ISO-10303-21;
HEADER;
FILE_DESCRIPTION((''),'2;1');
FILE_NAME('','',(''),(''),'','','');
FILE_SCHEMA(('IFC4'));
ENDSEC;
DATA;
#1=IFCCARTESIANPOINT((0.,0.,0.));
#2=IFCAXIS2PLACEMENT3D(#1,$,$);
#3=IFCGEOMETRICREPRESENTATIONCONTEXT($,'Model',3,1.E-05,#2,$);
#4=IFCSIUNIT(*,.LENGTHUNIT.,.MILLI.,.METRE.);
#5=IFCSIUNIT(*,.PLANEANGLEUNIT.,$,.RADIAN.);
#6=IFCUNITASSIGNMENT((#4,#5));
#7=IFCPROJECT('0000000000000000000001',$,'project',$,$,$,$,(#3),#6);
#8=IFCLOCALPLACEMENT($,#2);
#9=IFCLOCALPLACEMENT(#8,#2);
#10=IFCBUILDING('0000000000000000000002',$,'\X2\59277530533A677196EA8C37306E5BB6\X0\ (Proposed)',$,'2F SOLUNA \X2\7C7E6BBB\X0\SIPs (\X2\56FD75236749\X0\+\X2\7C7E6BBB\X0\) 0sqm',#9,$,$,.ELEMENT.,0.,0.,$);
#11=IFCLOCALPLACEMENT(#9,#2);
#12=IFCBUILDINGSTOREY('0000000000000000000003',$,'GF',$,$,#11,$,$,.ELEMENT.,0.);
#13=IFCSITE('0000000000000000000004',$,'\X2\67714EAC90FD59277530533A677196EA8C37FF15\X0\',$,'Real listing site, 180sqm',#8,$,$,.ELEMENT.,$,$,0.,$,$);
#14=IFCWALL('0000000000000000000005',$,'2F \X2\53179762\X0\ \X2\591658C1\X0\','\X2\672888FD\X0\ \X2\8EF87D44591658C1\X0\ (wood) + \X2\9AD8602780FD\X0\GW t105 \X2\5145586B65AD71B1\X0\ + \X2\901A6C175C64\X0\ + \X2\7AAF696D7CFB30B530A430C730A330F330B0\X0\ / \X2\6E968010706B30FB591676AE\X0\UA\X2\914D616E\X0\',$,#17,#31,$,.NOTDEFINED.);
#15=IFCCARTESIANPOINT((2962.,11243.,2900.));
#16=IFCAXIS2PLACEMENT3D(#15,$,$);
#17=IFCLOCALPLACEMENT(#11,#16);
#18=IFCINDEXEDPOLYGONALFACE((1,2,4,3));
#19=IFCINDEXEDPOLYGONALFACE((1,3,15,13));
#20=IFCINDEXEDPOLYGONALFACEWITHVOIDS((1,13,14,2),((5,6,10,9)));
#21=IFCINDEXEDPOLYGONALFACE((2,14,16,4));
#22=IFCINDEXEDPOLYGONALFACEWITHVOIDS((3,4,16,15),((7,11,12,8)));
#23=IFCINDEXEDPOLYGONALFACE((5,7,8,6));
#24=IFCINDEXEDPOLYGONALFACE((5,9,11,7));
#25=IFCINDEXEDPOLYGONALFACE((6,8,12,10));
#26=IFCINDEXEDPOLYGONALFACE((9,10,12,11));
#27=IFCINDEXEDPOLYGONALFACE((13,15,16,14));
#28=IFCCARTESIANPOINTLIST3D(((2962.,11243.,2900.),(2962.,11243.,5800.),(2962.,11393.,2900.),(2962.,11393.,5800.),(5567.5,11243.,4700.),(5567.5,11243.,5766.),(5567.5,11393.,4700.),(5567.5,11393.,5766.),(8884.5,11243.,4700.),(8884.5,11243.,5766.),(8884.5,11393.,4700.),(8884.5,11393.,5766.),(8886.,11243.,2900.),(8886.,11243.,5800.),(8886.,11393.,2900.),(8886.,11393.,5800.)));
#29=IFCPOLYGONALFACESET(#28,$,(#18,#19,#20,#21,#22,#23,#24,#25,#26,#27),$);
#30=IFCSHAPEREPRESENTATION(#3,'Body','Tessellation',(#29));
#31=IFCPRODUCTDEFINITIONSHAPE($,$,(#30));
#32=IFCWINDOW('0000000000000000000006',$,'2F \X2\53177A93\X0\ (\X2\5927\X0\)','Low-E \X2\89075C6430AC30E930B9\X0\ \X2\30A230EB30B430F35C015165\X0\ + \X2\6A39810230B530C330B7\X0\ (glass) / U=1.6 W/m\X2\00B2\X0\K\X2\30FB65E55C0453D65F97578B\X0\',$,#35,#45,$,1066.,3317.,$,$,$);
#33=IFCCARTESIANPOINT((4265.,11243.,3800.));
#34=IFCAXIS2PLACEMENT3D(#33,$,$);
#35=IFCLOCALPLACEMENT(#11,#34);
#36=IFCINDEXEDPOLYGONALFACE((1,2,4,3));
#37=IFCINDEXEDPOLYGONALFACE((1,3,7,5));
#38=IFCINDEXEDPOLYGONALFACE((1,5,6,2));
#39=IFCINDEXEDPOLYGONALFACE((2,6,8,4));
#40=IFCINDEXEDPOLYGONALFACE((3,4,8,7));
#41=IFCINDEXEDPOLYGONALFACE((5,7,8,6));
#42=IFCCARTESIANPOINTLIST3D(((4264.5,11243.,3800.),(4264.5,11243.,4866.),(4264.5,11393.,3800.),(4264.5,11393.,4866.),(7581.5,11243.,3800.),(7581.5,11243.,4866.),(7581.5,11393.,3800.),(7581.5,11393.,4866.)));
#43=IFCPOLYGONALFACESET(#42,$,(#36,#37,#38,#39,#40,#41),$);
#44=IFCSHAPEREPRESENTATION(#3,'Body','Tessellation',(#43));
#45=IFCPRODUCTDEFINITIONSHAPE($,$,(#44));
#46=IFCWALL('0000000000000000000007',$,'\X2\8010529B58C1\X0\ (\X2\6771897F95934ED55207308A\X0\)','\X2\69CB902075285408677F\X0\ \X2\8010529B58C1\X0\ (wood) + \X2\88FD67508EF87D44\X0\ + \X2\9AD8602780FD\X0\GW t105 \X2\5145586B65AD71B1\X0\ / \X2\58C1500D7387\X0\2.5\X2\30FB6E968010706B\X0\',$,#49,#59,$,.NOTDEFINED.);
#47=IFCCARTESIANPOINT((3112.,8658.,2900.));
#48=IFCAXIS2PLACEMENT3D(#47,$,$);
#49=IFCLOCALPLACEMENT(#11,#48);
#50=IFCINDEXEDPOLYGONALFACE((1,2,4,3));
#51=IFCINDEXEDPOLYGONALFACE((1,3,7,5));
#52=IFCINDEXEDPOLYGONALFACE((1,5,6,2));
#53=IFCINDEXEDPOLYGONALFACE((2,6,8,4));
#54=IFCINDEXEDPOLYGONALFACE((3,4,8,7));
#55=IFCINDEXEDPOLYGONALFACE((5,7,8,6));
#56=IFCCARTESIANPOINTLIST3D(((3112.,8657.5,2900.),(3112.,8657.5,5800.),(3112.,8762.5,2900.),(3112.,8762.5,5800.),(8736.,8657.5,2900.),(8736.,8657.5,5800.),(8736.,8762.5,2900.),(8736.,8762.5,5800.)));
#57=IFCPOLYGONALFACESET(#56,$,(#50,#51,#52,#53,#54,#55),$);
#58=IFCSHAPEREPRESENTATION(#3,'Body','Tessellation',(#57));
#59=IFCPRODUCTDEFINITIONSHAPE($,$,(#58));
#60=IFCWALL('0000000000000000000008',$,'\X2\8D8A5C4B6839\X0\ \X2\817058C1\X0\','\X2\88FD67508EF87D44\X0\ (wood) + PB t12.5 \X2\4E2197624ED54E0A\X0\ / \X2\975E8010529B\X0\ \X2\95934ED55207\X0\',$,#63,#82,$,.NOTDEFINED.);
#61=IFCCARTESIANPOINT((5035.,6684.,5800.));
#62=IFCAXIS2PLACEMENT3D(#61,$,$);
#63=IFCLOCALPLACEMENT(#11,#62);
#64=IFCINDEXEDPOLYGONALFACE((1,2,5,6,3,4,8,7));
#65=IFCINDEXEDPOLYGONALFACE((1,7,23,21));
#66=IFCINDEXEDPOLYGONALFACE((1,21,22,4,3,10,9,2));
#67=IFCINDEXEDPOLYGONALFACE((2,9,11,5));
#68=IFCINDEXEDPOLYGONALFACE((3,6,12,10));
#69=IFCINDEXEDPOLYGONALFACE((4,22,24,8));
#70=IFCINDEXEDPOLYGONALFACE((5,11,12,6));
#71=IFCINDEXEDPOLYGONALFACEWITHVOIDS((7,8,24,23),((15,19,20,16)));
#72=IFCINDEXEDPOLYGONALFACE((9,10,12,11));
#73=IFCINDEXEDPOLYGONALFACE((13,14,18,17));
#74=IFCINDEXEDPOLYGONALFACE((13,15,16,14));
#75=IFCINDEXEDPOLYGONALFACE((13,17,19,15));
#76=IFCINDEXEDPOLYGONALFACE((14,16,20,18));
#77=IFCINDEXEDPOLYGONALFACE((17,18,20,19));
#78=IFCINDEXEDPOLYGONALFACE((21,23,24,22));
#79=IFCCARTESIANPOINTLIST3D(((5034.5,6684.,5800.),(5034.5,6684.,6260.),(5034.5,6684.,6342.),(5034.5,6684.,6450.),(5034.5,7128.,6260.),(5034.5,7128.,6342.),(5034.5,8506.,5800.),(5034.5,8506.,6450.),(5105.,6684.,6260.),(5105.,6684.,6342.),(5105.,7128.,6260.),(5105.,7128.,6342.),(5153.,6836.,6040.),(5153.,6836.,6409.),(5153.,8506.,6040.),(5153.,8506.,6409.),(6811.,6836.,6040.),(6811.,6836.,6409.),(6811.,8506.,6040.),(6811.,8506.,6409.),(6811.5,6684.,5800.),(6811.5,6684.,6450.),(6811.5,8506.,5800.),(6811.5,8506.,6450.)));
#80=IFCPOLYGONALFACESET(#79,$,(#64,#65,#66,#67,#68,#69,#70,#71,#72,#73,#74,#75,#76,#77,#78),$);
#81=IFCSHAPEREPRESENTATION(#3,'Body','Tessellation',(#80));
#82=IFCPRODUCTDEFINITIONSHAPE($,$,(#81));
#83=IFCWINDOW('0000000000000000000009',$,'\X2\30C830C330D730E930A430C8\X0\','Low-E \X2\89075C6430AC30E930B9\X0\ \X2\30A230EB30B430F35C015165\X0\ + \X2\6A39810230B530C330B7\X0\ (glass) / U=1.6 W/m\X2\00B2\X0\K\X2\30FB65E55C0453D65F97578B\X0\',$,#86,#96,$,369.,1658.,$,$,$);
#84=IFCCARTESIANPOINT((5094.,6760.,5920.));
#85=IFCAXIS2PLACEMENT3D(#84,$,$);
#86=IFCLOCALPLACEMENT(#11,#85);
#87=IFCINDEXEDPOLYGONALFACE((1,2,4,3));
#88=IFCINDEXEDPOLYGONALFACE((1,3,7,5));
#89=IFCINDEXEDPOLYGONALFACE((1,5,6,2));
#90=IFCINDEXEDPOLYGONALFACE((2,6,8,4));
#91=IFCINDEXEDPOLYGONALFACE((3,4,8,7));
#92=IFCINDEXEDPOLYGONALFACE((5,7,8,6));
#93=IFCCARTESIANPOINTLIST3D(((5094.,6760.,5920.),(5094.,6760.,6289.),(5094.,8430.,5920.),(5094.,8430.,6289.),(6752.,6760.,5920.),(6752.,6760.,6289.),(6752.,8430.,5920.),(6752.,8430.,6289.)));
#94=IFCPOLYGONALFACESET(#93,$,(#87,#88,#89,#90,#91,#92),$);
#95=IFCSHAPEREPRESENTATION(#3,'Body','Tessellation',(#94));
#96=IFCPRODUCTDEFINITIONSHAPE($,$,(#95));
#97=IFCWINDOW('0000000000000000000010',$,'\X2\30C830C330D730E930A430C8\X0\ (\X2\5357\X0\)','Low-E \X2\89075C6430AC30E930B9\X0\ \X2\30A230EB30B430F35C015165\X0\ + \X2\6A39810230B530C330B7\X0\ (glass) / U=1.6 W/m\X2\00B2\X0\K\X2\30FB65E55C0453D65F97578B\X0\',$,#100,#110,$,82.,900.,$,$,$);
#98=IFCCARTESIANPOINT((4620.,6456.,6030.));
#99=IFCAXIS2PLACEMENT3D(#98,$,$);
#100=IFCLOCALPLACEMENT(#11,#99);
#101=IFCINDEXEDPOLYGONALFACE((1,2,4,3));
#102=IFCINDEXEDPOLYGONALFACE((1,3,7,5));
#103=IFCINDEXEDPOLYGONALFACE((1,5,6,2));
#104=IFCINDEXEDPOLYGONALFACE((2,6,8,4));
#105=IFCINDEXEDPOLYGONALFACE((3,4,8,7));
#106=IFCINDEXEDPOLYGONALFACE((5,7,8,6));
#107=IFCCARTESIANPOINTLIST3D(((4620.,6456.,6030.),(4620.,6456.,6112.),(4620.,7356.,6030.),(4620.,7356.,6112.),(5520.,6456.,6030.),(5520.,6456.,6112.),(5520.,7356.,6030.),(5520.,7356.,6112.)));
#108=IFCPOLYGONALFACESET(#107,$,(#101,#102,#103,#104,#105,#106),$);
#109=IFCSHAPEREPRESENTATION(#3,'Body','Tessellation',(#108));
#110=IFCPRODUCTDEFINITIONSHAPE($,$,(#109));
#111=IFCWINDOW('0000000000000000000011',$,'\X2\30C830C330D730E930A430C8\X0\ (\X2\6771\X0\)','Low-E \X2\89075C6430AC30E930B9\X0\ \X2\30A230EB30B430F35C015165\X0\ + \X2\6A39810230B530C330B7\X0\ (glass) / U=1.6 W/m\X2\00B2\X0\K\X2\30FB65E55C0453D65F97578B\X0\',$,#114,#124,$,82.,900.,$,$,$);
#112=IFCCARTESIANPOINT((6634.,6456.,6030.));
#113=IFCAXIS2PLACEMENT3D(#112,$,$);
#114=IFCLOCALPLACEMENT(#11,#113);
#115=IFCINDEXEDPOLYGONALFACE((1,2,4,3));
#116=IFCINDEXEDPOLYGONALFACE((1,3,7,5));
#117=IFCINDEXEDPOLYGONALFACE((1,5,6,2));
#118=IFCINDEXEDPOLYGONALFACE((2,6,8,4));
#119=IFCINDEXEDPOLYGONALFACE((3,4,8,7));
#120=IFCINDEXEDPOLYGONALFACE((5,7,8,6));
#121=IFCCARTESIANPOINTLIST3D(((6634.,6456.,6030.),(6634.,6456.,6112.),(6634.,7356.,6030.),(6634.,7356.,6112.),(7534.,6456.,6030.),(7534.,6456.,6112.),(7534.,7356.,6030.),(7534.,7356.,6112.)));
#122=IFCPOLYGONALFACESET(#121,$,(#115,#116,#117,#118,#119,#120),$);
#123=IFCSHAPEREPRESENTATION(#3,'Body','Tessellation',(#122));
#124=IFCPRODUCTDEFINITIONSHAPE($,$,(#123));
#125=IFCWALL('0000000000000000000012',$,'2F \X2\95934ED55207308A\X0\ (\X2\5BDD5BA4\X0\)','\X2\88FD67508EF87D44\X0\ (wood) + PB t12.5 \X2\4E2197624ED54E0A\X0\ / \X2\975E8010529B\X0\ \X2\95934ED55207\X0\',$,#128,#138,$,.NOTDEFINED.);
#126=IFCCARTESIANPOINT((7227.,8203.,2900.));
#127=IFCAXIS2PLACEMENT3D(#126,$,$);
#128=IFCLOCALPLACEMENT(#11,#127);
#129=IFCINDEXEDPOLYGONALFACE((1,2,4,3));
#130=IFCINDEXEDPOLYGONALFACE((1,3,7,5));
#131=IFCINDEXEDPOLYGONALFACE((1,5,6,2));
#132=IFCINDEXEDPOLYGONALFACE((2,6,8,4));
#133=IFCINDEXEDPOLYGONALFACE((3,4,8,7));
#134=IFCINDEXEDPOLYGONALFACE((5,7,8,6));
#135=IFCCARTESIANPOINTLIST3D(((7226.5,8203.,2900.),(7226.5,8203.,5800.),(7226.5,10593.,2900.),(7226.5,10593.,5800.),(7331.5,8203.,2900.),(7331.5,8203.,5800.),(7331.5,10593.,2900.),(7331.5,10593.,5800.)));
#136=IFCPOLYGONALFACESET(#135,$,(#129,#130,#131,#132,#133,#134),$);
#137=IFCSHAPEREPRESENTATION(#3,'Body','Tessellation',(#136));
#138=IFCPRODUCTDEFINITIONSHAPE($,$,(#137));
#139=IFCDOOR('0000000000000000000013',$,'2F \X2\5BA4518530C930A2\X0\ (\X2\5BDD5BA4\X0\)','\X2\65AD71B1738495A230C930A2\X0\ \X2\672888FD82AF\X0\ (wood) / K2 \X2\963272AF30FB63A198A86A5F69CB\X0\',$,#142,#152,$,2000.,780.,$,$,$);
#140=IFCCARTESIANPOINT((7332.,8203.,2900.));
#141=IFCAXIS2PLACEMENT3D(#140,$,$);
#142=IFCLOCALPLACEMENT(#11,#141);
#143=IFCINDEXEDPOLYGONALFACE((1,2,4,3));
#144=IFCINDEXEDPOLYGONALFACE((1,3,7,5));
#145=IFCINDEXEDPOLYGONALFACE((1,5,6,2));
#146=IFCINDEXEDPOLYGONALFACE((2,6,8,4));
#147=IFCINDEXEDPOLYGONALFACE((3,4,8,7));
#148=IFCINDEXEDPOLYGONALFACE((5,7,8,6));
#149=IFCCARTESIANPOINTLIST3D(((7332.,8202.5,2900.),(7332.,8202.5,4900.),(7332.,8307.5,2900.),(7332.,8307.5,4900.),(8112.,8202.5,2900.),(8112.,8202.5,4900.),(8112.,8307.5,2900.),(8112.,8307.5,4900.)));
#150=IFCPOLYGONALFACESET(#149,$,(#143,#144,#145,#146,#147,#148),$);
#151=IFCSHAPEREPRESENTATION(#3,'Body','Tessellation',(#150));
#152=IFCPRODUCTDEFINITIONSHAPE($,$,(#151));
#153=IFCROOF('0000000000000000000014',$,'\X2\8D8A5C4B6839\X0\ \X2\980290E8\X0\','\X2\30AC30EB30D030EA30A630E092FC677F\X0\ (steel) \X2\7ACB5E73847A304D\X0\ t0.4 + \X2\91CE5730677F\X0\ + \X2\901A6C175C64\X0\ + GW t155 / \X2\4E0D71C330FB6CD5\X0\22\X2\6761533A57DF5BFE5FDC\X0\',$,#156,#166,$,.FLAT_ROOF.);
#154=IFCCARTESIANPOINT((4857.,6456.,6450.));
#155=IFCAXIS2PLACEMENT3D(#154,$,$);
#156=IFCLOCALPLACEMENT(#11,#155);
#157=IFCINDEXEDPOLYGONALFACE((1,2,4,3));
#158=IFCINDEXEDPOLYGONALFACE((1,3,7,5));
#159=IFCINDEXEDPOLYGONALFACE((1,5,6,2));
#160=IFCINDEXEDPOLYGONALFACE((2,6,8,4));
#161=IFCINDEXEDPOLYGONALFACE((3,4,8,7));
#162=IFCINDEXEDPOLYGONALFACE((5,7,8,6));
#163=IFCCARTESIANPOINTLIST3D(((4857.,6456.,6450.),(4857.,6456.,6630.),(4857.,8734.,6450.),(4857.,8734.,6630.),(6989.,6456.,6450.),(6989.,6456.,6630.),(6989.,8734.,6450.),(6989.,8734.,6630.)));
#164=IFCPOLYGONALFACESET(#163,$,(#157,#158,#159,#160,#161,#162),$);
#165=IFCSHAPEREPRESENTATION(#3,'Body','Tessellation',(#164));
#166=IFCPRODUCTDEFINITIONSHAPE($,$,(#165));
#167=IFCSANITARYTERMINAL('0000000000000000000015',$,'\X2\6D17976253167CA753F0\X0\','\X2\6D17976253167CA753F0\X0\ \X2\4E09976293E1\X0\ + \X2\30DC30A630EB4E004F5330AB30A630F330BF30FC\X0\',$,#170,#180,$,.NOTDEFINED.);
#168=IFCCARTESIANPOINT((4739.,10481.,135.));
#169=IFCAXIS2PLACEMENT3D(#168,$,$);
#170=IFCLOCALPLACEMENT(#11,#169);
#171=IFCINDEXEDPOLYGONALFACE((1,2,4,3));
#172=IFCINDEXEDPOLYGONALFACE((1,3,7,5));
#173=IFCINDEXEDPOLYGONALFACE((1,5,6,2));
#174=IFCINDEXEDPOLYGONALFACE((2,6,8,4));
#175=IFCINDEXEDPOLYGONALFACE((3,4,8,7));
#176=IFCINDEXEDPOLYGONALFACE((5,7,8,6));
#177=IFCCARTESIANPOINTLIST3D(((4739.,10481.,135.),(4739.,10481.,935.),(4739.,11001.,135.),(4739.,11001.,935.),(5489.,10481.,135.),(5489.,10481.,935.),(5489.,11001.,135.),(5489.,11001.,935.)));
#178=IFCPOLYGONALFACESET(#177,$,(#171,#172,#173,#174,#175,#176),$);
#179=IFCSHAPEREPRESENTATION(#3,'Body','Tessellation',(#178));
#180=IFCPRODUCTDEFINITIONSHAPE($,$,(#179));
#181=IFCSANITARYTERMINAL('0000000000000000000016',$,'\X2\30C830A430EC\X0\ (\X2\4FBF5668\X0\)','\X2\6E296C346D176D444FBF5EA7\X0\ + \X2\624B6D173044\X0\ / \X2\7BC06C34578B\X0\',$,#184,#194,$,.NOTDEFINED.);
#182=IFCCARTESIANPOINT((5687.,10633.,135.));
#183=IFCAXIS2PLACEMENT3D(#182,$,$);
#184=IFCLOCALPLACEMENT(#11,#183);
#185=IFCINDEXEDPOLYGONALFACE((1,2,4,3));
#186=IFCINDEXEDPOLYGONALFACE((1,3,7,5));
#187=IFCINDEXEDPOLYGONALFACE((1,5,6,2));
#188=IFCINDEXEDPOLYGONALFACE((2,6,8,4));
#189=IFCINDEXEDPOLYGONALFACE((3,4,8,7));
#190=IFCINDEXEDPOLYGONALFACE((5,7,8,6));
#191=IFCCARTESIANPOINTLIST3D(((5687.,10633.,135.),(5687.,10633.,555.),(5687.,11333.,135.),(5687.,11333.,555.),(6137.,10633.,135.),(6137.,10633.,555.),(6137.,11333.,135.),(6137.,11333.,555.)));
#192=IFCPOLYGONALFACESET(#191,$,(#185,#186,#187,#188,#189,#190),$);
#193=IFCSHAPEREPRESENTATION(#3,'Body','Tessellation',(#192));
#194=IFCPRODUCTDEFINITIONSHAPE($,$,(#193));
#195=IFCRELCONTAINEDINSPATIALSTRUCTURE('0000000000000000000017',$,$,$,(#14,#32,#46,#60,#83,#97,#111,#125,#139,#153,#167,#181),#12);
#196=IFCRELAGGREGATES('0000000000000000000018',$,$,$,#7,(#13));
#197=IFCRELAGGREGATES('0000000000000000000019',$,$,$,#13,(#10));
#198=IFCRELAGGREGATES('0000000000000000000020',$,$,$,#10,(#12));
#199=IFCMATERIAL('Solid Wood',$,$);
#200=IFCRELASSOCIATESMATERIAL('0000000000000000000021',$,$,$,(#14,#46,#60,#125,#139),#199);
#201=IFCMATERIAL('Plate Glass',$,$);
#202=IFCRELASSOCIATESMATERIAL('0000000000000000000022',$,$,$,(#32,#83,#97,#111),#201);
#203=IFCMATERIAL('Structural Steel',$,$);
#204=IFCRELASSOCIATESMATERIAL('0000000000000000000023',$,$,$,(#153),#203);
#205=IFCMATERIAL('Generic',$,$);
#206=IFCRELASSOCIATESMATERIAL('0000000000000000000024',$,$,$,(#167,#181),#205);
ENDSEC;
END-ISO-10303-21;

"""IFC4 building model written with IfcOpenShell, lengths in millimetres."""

from ifc_helpers import new_model, si_unit, frame, frame_2d, origin, place, context, project, spatial, rectangle, extrude, material, element, fill, save


model = new_model("IFC4")

# Units and contexts
model_context = context("Model", 3, precision=1e-05, world=origin())
ifc_project = project(units=[si_unit("LENGTHUNIT", "METRE", prefix="MILLI"), si_unit("PLANEANGLEUNIT", "RADIAN")], contexts=[model_context])

# Site, building, storey
site_placement = place(None, origin())
site = spatial("IfcSite", under=ifc_project, at=site_placement, Name="東京都大田区東雪谷５", ObjectType="Real listing site, 180sqm", CompositionType="ELEMENT", RefElevation=0.0)
building_placement = place(site_placement, origin())
building = spatial("IfcBuilding", under=site, at=building_placement, Name="大田区東雪谷の家 (Proposed)", ObjectType="2F SOLUNA 籾殻SIPs (国産杉+籾殻) 0sqm", CompositionType="ELEMENT", ElevationOfRefHeight=0.0, ElevationOfTerrain=0.0)
storey_placement = place(building_placement, origin())
storey = spatial("IfcBuildingStorey", under=building, at=storey_placement, Name="GF", CompositionType="ELEMENT", Elevation=0.0)

# Wall, opening, window
ifc_material_1 = material(Name="Solid Wood")
wall_1_placement = place(storey_placement, frame((2962.0, 11243.0, 2900.0)))
wall_1 = element("IfcWall", 1, at=wall_1_placement, inside=storey, material=ifc_material_1, Name="2F 北面 外壁", Description="木製 軸組外壁 (wood) + 高性能GW t105 充填断熱 + 通気層 + 窯業系サイディング / 準耐火・外皮UA配慮", PredefinedType="NOTDEFINED", context=model_context, shape_type="SweptSolid", body=[
    extrude(rectangle(XDim=5924.0, YDim=150.0, at=frame_2d((2962.0, 75.0))), frame((2962.0, 11243.0, 2900.0)), (0.0, 0.0, 1.0), 2900.0),
])
opening_1_placement = place(storey_placement, frame((4265.0, 11243.0, 3800.0)))
opening_1 = element("IfcOpeningElement", 2, at=opening_1_placement, cuts=wall_1, PredefinedType="NOTDEFINED", context=model_context, shape_type="SweptSolid", body=[
    extrude(rectangle(XDim=3317.0, YDim=150.0, at=frame_2d((1658.0, 75.0))), frame((4265.0, 11243.0, 3800.0)), (0.0, 0.0, 1.0), 1066.0),
])
ifc_material_2 = material(Name="Plate Glass")
window_1_placement = place(storey_placement, frame((4265.0, 11243.0, 3800.0)))
window_1 = element("IfcWindow", 3, at=window_1_placement, inside=storey, material=ifc_material_2, Name="2F 北窓 (大)", Description="Low-E 複層ガラス アルゴン封入 + 樹脂サッシ (glass) / U=1.6 W/m²K・日射取得型", OverallHeight=1066.0, OverallWidth=3317.0, context=model_context, shape_type="SweptSolid", body=[
    extrude(rectangle(XDim=3317.0, YDim=150.0, at=frame_2d((1658.0, 75.0))), frame((4265.0, 11243.0, 3800.0)), (0.0, 0.0, 1.0), 1066.0),
])
fill(opening_1, window_1)

# Wall
wall_2_placement = place(storey_placement, frame((3112.0, 8658.0, 2900.0)))
element("IfcWall", 4, at=wall_2_placement, inside=storey, material=ifc_material_1, Name="耐力壁 (東西間仕切り)", Description="構造用合板 耐力壁 (wood) + 製材軸組 + 高性能GW t105 充填断熱 / 壁倍率2.5・準耐火", PredefinedType="NOTDEFINED", context=model_context, shape_type="SweptSolid", body=[
    extrude(rectangle(XDim=5624.0, YDim=105.0, at=frame_2d((2812.0, 52.0))), frame((3112.0, 8658.0, 2900.0)), (0.0, 0.0, 1.0), 2900.0),
])

# Wall, openings, windows
wall_3_placement = place(storey_placement, frame((5035.0, 6684.0, 5800.0)))
wall_3 = element("IfcWall", 5, at=wall_3_placement, inside=storey, material=ifc_material_1, Name="越屋根 腰壁", Description="製材軸組 (wood) + PB t12.5 両面仕上 / 非耐力 間仕切", PredefinedType="NOTDEFINED", context=model_context, shape_type="SweptSolid", body=[
    extrude(rectangle(XDim=1777.0, YDim=1822.0, at=frame_2d((888.0, 911.0))), frame((5035.0, 6684.0, 5800.0)), (0.0, 0.0, 1.0), 650.0),
])
opening_2_placement = place(storey_placement, frame((5094.0, 6760.0, 5920.0)))
opening_2 = element("IfcOpeningElement", 6, at=opening_2_placement, cuts=wall_3, PredefinedType="NOTDEFINED", context=model_context, shape_type="SweptSolid", body=[
    extrude(rectangle(XDim=1658.0, YDim=1670.0, at=frame_2d((829.0, 835.0))), frame((5094.0, 6760.0, 5920.0)), (0.0, 0.0, 1.0), 369.0),
])
opening_3_placement = place(storey_placement, frame((4620.0, 6456.0, 6030.0)))
opening_3 = element("IfcOpeningElement", 7, at=opening_3_placement, cuts=wall_3, PredefinedType="NOTDEFINED", context=model_context, shape_type="SweptSolid", body=[
    extrude(rectangle(XDim=900.0, YDim=900.0, at=frame_2d((450.0, 450.0))), frame((4620.0, 6456.0, 6030.0)), (0.0, 0.0, 1.0), 82.0),
])
opening_4_placement = place(storey_placement, frame((6634.0, 6456.0, 6030.0)))
opening_4 = element("IfcOpeningElement", 8, at=opening_4_placement, cuts=wall_3, PredefinedType="NOTDEFINED", context=model_context, shape_type="SweptSolid", body=[
    extrude(rectangle(XDim=900.0, YDim=900.0, at=frame_2d((450.0, 450.0))), frame((6634.0, 6456.0, 6030.0)), (0.0, 0.0, 1.0), 82.0),
])
window_2_placement = place(storey_placement, frame((5094.0, 6760.0, 5920.0)))
window_2 = element("IfcWindow", 9, at=window_2_placement, inside=storey, material=ifc_material_2, Name="トップライト", Description="Low-E 複層ガラス アルゴン封入 + 樹脂サッシ (glass) / U=1.6 W/m²K・日射取得型", OverallHeight=369.0, OverallWidth=1658.0, context=model_context, shape_type="SweptSolid", body=[
    extrude(rectangle(XDim=1658.0, YDim=1670.0, at=frame_2d((829.0, 835.0))), frame((5094.0, 6760.0, 5920.0)), (0.0, 0.0, 1.0), 369.0),
])
fill(opening_2, window_2)
window_3_placement = place(storey_placement, frame((4620.0, 6456.0, 6030.0)))
window_3 = element("IfcWindow", 10, at=window_3_placement, inside=storey, material=ifc_material_2, Name="トップライト (南)", Description="Low-E 複層ガラス アルゴン封入 + 樹脂サッシ (glass) / U=1.6 W/m²K・日射取得型", OverallHeight=82.0, OverallWidth=900.0, context=model_context, shape_type="SweptSolid", body=[
    extrude(rectangle(XDim=900.0, YDim=900.0, at=frame_2d((450.0, 450.0))), frame((4620.0, 6456.0, 6030.0)), (0.0, 0.0, 1.0), 82.0),
])
fill(opening_3, window_3)
window_4_placement = place(storey_placement, frame((6634.0, 6456.0, 6030.0)))
window_4 = element("IfcWindow", 11, at=window_4_placement, inside=storey, material=ifc_material_2, Name="トップライト (東)", Description="Low-E 複層ガラス アルゴン封入 + 樹脂サッシ (glass) / U=1.6 W/m²K・日射取得型", OverallHeight=82.0, OverallWidth=900.0, context=model_context, shape_type="SweptSolid", body=[
    extrude(rectangle(XDim=900.0, YDim=900.0, at=frame_2d((450.0, 450.0))), frame((6634.0, 6456.0, 6030.0)), (0.0, 0.0, 1.0), 82.0),
])
fill(opening_4, window_4)

# Wall
wall_4_placement = place(storey_placement, frame((7227.0, 8203.0, 2900.0)))
element("IfcWall", 12, at=wall_4_placement, inside=storey, material=ifc_material_1, Name="2F 間仕切り (寝室)", Description="製材軸組 (wood) + PB t12.5 両面仕上 / 非耐力 間仕切", PredefinedType="NOTDEFINED", context=model_context, shape_type="SweptSolid", body=[
    extrude(rectangle(XDim=105.0, YDim=2390.0, at=frame_2d((52.0, 1195.0))), frame((7227.0, 8203.0, 2900.0)), (0.0, 0.0, 1.0), 2900.0),
])

# Door
door_placement = place(storey_placement, frame((7332.0, 8203.0, 2900.0)))
element("IfcDoor", 13, at=door_placement, inside=storey, material=ifc_material_1, Name="2F 室内ドア (寝室)", Description="断熱玄関ドア 木製芯 (wood) / K2 防犯・採風機構", OverallHeight=2000.0, OverallWidth=780.0, context=model_context, shape_type="SweptSolid", body=[
    extrude(rectangle(XDim=780.0, YDim=105.0, at=frame_2d((390.0, 52.0))), frame((7332.0, 8203.0, 2900.0)), (0.0, 0.0, 1.0), 2000.0),
])

# Roof
ifc_material_3 = material(Name="Structural Steel")
roof_placement = place(storey_placement, frame((4857.0, 6456.0, 6450.0)))
element("IfcRoof", 14, at=roof_placement, inside=storey, material=ifc_material_3, Name="越屋根 頂部", Description="ガルバリウム鋼板 (steel) 立平葺き t0.4 + 野地板 + 通気層 + GW t155 / 不燃・法22条区域対応", PredefinedType="FLAT_ROOF", context=model_context, shape_type="SweptSolid", body=[
    extrude(rectangle(XDim=2132.0, YDim=2278.0, at=frame_2d((1066.0, 1139.0))), frame((4857.0, 6456.0, 6450.0)), (0.0, 0.0, 1.0), 180.0),
])

# Sanitary terminals
ifc_material_4 = material(Name="Generic")
sanitary_terminal_1_placement = place(storey_placement, frame((4739.0, 10481.0, 135.0)))
element("IfcSanitaryTerminal", 15, at=sanitary_terminal_1_placement, inside=storey, material=ifc_material_4, Name="洗面化粧台", Description="洗面化粧台 三面鏡 + ボウル一体カウンター", PredefinedType="NOTDEFINED", context=model_context, shape_type="SweptSolid", body=[
    extrude(rectangle(XDim=750.0, YDim=520.0, at=frame_2d((375.0, 260.0))), frame((4739.0, 10481.0, 135.0)), (0.0, 0.0, 1.0), 800.0),
])
sanitary_terminal_2_placement = place(storey_placement, frame((5687.0, 10633.0, 135.0)))
element("IfcSanitaryTerminal", 16, at=sanitary_terminal_2_placement, inside=storey, material=ifc_material_4, Name="トイレ (便器)", Description="温水洗浄便座 + 手洗い / 節水型", PredefinedType="NOTDEFINED", context=model_context, shape_type="SweptSolid", body=[
    extrude(rectangle(XDim=450.0, YDim=700.0, at=frame_2d((225.0, 350.0))), frame((5687.0, 10633.0, 135.0)), (0.0, 0.0, 1.0), 420.0),
])

save(model, "model.ifc")
